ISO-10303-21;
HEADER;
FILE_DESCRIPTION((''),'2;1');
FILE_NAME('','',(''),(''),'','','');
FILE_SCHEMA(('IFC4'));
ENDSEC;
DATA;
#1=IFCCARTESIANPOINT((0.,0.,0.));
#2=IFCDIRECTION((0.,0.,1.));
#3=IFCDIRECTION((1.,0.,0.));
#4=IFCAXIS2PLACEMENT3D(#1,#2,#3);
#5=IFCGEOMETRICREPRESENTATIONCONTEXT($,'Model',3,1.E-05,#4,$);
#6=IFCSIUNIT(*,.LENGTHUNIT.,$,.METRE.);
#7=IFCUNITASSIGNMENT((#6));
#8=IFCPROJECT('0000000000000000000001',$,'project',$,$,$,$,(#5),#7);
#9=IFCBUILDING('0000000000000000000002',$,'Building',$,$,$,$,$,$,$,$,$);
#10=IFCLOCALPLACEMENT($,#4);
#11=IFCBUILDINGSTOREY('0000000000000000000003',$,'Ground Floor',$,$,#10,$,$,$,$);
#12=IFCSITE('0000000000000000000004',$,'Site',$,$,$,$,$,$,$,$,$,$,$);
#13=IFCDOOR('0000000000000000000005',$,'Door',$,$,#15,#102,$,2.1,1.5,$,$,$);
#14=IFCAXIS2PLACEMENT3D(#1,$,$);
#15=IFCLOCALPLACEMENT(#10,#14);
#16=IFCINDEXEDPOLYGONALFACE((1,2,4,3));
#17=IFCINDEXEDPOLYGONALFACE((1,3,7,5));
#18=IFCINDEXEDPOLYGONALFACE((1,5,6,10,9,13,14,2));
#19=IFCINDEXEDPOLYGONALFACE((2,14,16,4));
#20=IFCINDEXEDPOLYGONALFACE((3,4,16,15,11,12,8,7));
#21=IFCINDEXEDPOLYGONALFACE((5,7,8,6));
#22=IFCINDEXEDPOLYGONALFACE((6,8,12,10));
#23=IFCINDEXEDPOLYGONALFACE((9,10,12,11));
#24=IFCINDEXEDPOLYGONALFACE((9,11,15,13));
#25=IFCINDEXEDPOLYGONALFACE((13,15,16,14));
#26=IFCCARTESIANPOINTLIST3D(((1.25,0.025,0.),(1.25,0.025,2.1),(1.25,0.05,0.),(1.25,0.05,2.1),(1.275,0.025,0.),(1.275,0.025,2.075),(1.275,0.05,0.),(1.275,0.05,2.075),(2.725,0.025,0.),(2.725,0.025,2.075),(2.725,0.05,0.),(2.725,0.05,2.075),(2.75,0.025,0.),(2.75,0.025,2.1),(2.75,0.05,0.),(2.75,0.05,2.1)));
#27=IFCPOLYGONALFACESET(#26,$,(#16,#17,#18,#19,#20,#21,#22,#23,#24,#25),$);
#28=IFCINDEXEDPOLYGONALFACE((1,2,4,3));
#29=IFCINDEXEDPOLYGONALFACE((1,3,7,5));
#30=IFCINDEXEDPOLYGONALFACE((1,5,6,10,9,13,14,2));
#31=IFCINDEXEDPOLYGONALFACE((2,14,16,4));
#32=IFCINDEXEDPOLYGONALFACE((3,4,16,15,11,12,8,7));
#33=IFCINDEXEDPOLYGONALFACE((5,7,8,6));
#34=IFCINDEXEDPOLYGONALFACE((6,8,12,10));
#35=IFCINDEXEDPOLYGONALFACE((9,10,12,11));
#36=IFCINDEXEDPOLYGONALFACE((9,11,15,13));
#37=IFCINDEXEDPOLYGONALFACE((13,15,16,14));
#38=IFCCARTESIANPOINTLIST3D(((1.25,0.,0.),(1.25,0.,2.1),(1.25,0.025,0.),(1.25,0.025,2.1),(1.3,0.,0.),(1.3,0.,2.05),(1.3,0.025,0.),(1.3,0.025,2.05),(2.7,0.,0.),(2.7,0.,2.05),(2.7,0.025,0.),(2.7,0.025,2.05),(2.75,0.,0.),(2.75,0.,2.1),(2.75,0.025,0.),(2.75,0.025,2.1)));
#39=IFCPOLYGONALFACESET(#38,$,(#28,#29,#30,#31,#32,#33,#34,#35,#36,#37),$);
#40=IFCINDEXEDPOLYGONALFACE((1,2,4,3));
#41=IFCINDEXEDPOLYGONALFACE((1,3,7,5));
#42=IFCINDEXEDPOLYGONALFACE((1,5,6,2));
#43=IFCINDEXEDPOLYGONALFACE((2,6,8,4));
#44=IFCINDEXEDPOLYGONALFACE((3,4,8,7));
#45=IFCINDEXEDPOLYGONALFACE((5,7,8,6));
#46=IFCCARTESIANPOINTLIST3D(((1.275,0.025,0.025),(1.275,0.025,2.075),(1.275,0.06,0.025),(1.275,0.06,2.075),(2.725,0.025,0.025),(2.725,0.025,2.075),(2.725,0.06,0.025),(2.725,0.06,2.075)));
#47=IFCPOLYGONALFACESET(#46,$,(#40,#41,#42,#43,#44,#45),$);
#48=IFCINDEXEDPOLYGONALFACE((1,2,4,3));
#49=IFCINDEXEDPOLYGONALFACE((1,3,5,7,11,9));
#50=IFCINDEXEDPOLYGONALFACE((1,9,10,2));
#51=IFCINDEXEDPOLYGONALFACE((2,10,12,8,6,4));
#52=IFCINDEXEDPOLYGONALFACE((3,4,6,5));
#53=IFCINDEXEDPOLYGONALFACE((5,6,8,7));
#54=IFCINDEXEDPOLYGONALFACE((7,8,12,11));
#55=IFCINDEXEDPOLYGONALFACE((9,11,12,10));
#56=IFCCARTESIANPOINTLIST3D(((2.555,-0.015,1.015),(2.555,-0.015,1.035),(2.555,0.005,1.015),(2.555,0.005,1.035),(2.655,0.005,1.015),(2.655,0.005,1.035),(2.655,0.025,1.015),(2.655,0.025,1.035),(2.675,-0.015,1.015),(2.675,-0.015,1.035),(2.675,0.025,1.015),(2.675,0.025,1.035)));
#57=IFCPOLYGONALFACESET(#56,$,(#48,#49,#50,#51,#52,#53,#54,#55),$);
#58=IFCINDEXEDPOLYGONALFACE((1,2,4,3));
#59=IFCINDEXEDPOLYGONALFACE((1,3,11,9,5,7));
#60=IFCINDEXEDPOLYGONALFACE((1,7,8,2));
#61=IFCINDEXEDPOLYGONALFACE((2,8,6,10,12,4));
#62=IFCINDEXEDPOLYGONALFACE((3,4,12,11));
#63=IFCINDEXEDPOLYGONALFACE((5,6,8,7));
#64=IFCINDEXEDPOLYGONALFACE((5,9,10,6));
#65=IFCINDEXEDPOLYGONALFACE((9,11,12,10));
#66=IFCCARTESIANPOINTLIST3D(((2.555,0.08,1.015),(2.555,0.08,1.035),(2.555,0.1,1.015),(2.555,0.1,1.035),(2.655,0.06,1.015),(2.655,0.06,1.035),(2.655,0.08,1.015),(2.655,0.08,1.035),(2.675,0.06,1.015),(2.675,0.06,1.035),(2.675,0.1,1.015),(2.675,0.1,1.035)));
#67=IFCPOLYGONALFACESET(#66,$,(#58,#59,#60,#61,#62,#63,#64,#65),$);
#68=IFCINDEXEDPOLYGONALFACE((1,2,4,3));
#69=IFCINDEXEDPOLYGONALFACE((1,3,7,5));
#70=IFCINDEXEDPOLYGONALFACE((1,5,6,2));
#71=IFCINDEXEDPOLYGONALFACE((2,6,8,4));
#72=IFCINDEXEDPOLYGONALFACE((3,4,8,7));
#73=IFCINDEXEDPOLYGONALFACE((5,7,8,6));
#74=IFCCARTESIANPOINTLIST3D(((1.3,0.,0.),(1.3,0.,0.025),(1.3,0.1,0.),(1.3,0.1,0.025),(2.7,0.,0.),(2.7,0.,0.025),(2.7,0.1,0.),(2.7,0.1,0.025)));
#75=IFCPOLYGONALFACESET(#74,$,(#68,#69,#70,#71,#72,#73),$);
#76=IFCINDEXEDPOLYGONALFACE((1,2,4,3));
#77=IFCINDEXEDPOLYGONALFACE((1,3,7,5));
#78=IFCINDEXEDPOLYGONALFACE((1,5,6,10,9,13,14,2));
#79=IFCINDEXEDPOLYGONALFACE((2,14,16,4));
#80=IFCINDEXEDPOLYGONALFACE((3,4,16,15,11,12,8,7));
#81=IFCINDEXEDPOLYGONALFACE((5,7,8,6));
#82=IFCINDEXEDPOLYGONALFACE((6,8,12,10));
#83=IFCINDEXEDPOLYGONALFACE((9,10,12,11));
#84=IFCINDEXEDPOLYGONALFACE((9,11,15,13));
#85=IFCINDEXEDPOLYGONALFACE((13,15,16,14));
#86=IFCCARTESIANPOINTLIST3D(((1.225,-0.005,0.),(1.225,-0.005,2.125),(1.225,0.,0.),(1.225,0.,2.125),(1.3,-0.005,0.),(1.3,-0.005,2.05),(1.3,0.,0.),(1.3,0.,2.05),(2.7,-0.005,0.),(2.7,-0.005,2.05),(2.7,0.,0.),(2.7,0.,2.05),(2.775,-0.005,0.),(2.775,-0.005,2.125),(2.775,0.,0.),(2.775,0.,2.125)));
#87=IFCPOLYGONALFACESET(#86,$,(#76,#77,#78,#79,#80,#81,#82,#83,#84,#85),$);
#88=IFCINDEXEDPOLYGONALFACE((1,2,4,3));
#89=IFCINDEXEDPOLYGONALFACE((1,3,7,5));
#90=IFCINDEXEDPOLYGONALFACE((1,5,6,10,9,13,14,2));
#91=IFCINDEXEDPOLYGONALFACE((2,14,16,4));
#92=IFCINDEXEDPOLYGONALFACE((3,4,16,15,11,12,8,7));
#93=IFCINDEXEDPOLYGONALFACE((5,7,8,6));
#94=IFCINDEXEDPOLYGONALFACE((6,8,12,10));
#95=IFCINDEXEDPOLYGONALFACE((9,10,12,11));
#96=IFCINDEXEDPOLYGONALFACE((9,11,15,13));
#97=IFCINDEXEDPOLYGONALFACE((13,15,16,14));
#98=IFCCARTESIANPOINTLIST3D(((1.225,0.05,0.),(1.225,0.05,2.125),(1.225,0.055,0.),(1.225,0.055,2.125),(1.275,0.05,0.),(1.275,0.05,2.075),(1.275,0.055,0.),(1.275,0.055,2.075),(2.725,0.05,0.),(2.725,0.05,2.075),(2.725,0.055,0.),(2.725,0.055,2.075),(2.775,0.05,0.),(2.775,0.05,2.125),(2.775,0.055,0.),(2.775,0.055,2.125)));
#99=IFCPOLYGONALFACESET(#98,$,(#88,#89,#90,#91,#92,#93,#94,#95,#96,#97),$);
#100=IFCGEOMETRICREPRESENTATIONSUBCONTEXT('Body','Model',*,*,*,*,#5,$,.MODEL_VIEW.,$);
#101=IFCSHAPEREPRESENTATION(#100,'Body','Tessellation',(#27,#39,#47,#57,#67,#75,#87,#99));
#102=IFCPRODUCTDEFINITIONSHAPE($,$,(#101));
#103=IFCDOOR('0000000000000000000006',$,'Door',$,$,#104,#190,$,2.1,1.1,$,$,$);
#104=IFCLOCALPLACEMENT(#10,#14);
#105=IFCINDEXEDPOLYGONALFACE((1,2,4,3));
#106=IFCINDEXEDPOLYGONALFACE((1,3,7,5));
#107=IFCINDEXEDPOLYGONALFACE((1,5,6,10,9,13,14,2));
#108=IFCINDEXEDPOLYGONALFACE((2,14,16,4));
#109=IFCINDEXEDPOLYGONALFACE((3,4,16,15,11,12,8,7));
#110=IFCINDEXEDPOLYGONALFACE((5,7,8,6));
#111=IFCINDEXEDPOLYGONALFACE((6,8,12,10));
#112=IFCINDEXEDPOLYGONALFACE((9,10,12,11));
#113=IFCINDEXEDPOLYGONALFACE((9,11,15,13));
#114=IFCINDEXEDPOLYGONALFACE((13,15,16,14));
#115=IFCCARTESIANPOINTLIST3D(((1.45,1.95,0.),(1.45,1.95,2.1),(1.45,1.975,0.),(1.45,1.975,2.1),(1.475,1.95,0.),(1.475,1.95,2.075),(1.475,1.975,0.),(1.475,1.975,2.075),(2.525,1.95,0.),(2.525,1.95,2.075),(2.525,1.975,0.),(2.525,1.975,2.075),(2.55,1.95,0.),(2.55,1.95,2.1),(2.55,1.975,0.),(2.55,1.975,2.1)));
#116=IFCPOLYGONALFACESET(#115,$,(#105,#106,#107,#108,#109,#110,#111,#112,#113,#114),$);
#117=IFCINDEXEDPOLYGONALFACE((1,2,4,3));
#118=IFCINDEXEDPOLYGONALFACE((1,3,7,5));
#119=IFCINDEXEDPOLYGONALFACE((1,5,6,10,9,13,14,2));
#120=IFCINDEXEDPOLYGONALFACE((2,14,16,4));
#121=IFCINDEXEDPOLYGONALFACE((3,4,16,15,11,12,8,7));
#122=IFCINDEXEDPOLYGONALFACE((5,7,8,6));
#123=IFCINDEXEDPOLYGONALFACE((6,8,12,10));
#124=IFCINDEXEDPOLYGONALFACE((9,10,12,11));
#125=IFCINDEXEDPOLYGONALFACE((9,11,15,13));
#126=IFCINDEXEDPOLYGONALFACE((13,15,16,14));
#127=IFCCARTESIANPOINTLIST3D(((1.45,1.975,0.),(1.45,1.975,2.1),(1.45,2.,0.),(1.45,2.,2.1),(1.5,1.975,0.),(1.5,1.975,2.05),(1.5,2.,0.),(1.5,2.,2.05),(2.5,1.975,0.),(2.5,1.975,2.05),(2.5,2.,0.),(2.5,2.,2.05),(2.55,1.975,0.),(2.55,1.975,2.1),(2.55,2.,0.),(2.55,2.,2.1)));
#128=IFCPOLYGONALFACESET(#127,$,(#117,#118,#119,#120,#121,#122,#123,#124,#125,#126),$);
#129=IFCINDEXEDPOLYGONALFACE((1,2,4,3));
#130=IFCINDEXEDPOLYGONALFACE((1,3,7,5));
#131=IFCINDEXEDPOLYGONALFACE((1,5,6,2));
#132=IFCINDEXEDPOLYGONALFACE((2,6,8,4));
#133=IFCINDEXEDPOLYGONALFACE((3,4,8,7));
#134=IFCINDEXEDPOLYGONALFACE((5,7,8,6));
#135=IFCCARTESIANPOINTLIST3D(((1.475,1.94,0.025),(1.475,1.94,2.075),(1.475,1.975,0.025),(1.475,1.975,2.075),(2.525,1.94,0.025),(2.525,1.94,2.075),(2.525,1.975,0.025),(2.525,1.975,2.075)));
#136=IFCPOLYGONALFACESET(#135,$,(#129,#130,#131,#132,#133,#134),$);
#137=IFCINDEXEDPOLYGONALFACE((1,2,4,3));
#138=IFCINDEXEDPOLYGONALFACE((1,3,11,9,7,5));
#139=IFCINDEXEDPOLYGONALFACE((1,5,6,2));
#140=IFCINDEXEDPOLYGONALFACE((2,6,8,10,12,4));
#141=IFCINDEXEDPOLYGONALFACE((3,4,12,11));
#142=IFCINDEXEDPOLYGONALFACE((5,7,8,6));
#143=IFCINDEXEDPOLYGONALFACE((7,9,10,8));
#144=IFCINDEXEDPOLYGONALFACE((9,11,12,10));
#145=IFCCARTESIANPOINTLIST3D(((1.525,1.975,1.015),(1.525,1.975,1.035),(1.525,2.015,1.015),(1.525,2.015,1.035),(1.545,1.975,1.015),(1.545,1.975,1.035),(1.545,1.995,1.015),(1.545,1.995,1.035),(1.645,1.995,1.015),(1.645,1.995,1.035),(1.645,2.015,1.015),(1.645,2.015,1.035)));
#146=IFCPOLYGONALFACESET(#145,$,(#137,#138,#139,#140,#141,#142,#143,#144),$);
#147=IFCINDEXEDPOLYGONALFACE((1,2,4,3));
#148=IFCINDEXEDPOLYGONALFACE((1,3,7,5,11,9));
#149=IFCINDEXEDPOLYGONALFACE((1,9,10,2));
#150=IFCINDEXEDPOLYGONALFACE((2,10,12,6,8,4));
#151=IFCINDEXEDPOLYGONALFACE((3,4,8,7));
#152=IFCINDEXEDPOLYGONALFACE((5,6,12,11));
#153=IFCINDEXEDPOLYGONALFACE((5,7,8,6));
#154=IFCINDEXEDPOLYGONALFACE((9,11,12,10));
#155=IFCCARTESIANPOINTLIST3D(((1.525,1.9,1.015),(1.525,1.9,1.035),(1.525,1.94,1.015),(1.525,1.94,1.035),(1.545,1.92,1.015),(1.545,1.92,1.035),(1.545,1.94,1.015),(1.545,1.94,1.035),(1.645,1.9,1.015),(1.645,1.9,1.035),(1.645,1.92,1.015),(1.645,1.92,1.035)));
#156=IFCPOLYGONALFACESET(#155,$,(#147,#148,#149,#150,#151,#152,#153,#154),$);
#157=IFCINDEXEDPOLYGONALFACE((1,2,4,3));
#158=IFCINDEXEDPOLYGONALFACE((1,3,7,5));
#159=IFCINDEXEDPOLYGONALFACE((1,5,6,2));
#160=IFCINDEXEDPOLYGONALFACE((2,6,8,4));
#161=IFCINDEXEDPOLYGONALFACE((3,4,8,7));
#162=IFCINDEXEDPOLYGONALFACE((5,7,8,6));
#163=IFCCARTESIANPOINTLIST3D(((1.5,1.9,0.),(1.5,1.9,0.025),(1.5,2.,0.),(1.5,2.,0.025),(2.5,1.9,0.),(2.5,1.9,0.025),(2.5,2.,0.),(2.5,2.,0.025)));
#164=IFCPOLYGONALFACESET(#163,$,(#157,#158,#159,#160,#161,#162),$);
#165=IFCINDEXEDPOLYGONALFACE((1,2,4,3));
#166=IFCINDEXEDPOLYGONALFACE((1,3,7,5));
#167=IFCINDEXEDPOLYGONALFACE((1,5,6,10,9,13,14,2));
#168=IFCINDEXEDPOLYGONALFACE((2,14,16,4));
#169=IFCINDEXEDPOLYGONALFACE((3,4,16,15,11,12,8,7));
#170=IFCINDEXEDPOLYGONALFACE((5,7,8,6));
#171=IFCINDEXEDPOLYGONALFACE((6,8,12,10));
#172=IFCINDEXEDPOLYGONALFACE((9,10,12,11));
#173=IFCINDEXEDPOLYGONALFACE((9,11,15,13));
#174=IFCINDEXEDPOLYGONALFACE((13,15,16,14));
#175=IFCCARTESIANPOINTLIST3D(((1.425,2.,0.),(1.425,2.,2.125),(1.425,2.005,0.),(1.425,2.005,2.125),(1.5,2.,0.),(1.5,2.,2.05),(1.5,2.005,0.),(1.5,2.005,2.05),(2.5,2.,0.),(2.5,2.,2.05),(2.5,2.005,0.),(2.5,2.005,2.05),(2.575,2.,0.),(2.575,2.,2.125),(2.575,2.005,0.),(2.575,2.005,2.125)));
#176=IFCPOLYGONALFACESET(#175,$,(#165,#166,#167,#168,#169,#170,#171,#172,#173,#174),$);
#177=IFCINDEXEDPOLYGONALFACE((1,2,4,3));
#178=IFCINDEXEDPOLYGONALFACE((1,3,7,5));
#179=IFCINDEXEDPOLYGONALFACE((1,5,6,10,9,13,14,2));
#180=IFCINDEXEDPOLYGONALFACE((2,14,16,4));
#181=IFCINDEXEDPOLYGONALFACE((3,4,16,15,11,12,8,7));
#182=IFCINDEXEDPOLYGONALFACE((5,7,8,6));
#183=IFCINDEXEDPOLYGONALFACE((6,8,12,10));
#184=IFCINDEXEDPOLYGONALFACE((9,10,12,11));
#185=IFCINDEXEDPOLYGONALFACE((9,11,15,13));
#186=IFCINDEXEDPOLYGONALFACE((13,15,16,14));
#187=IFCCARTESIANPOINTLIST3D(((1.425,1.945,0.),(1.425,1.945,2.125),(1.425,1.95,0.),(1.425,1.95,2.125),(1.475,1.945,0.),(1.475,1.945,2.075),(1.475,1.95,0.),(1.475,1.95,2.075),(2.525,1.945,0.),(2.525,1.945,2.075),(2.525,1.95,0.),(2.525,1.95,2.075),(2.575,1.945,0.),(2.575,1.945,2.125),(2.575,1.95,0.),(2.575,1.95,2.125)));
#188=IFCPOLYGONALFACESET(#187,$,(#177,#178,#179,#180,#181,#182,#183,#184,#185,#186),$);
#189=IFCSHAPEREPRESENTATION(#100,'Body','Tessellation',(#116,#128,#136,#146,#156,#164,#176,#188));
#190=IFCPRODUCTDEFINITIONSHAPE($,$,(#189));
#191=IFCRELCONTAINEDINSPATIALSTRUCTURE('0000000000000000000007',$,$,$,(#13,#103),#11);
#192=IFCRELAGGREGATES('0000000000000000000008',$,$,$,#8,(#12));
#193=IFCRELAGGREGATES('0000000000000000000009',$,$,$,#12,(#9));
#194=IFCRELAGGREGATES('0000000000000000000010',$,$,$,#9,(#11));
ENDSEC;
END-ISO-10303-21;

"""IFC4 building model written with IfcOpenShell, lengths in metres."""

from ifc_helpers import new_model, si_unit, frame, origin_with_axes, place, context, subcontext, project, spatial, line, indexed_curve, outline, extrude, element, save


model = new_model("IFC4")

# Units and contexts
model_context = context("Model", 3, precision=1e-05, world=origin_with_axes())
body_context = subcontext(model_context, "Body", "Model", "MODEL_VIEW")
ifc_project = project(units=[si_unit("LENGTHUNIT", "METRE")], contexts=[model_context])

# Site, building, storey
site = spatial("IfcSite", under=ifc_project, Name="Site")
building = spatial("IfcBuilding", under=site, Name="Building")
storey_placement = place(None, origin_with_axes())
storey = spatial("IfcBuildingStorey", under=building, at=storey_placement, Name="Ground Floor")

# Doors
door_1_placement = place(storey_placement, frame((1.25, 0.0, 0.0), z_axis=(0.0, 0.0, 1.0), x_axis=(1.0, 0.0, 0.0)))
element("IfcDoor", 1, at=door_1_placement, inside=storey, Name="Door", OverallHeight=2.1, OverallWidth=1.5, context=body_context, shape_type="SweptSolid", body=[
    extrude(outline(indexed_curve([(0.0, 0.0), (0.0, 2.1), (1.5, 2.1), (1.5, 0.0), (1.475, 0.0), (1.475, 2.075), (0.025, 2.075), (0.025, 0.0)], segments=[line(1, 2, 3, 4, 5, 6, 7, 8, 1)])), frame((0.0, 0.025, 0.0), z_axis=(0.0, -1.0, 0.0), x_axis=(1.0, 0.0, 0.0)), (0.0, 0.0, -1.0), 0.025),
    extrude(outline(indexed_curve([(0.0, 0.0), (0.0, 2.1), (1.5, 2.1), (1.5, 0.0), (1.45, 0.0), (1.45, 2.05), (0.05, 2.05), (0.05, 0.0)], segments=[line(1, 2, 3, 4, 5, 6, 7, 8, 1)])), frame((0.0, 0.0, 0.0), z_axis=(0.0, -1.0, 0.0), x_axis=(1.0, 0.0, 0.0)), (0.0, 0.0, -1.0), 0.025),
    extrude(outline(indexed_curve([(0.0, 0.0), (1.45, 0.0), (1.45, 0.035), (0.0, 0.035)], segments=[line(1, 2, 3, 4, 1)])), frame((0.025, 0.025, 0.025), z_axis=(0.0, 0.0, 1.0), x_axis=(1.0, 0.0, 0.0)), (0.0, 0.0, 1.0), 2.05),
    extrude(outline(indexed_curve([(0.0, 0.0), (0.0, -0.04), (-0.12, -0.04), (-0.12, -0.02), (-0.02, -0.02), (-0.02, 0.0)], segments=[line(1, 2, 3, 4, 5, 6, 1)])), frame((1.425, 0.025, 1.015), z_axis=(0.0, 0.0, 1.0), x_axis=(1.0, 0.0, 0.0)), (0.0, 0.0, 1.0), 0.02),
    extrude(outline(indexed_curve([(0.0, 0.0), (0.0, 0.04), (-0.12, 0.04), (-0.12, 0.02), (-0.02, 0.02), (-0.02, 0.0)], segments=[line(1, 2, 3, 4, 5, 6, 1)])), frame((1.425, 0.06, 1.015), z_axis=(0.0, 0.0, 1.0), x_axis=(1.0, 0.0, 0.0)), (0.0, 0.0, 1.0), 0.02),
    extrude(outline(indexed_curve([(0.0, 0.0), (1.4, 0.0), (1.4, 0.1), (0.0, 0.1)], segments=[line(1, 2, 3, 4, 1)])), frame((0.05, 0.0, 0.0), z_axis=(0.0, 0.0, 1.0), x_axis=(1.0, 0.0, 0.0)), (0.0, 0.0, 1.0), 0.025),
    extrude(outline(indexed_curve([(0.0, 0.0), (0.0, 2.125), (1.55, 2.125), (1.55, 0.0), (1.475, 0.0), (1.475, 2.05), (0.075, 2.05), (0.075, 0.0)], segments=[line(1, 2, 3, 4, 5, 6, 7, 8, 1)])), frame((-0.025, -0.005, 0.0), z_axis=(0.0, -1.0, 0.0), x_axis=(1.0, 0.0, 0.0)), (0.0, 0.0, -1.0), 0.005),
    extrude(outline(indexed_curve([(0.0, 0.0), (0.0, 2.125), (1.55, 2.125), (1.55, 0.0), (1.5, 0.0), (1.5, 2.075), (0.05, 2.075), (0.05, 0.0)], segments=[line(1, 2, 3, 4, 5, 6, 7, 8, 1)])), frame((-0.025, 0.05, 0.0), z_axis=(0.0, -1.0, 0.0), x_axis=(1.0, 0.0, 0.0)), (0.0, 0.0, -1.0), 0.005),
])
door_2_placement = place(storey_placement, frame((2.55, 2.0, 0.0), z_axis=(0.0, 0.0, 1.0), x_axis=(-1.0, 0.0, 0.0)))
element("IfcDoor", 2, at=door_2_placement, inside=storey, Name="Door", OverallHeight=2.1, OverallWidth=1.1, context=body_context, shape_type="SweptSolid", body=[
    extrude(outline(indexed_curve([(0.0, 0.0), (0.0, 2.1), (1.1, 2.1), (1.1, 0.0), (1.075, 0.0), (1.075, 2.075), (0.025, 2.075), (0.025, 0.0)], segments=[line(1, 2, 3, 4, 5, 6, 7, 8, 1)])), frame((0.0, 0.025, 0.0), z_axis=(0.0, -1.0, 0.0), x_axis=(1.0, 0.0, 0.0)), (0.0, 0.0, -1.0), 0.025),
    extrude(outline(indexed_curve([(0.0, 0.0), (0.0, 2.1), (1.1, 2.1), (1.1, 0.0), (1.05, 0.0), (1.05, 2.05), (0.05, 2.05), (0.05, 0.0)], segments=[line(1, 2, 3, 4, 5, 6, 7, 8, 1)])), frame((0.0, 0.0, 0.0), z_axis=(0.0, -1.0, 0.0), x_axis=(1.0, 0.0, 0.0)), (0.0, 0.0, -1.0), 0.025),
    extrude(outline(indexed_curve([(0.0, 0.0), (1.05, 0.0), (1.05, 0.035), (0.0, 0.035)], segments=[line(1, 2, 3, 4, 1)])), frame((0.025, 0.025, 0.025), z_axis=(0.0, 0.0, 1.0), x_axis=(1.0, 0.0, 0.0)), (0.0, 0.0, 1.0), 2.05),
    extrude(outline(indexed_curve([(0.0, 0.0), (0.0, -0.04), (-0.12, -0.04), (-0.12, -0.02), (-0.02, -0.02), (-0.02, 0.0)], segments=[line(1, 2, 3, 4, 5, 6, 1)])), frame((1.025, 0.025, 1.015), z_axis=(0.0, 0.0, 1.0), x_axis=(1.0, 0.0, 0.0)), (0.0, 0.0, 1.0), 0.02),
    extrude(outline(indexed_curve([(0.0, 0.0), (0.0, 0.04), (-0.12, 0.04), (-0.12, 0.02), (-0.02, 0.02), (-0.02, 0.0)], segments=[line(1, 2, 3, 4, 5, 6, 1)])), frame((1.025, 0.06, 1.015), z_axis=(0.0, 0.0, 1.0), x_axis=(1.0, 0.0, 0.0)), (0.0, 0.0, 1.0), 0.02),
    extrude(outline(indexed_curve([(0.0, 0.0), (1.0, 0.0), (1.0, 0.1), (0.0, 0.1)], segments=[line(1, 2, 3, 4, 1)])), frame((0.05, 0.0, 0.0), z_axis=(0.0, 0.0, 1.0), x_axis=(1.0, 0.0, 0.0)), (0.0, 0.0, 1.0), 0.025),
    extrude(outline(indexed_curve([(0.0, 0.0), (0.0, 2.125), (1.15, 2.125), (1.15, 0.0), (1.075, 0.0), (1.075, 2.05), (0.075, 2.05), (0.075, 0.0)], segments=[line(1, 2, 3, 4, 5, 6, 7, 8, 1)])), frame((-0.025, -0.005, 0.0), z_axis=(0.0, -1.0, 0.0), x_axis=(1.0, 0.0, 0.0)), (0.0, 0.0, -1.0), 0.005),
    extrude(outline(indexed_curve([(0.0, 0.0), (0.0, 2.125), (1.15, 2.125), (1.15, 0.0), (1.1, 0.0), (1.1, 2.075), (0.05, 2.075), (0.05, 0.0)], segments=[line(1, 2, 3, 4, 5, 6, 7, 8, 1)])), frame((-0.025, 0.05, 0.0), z_axis=(0.0, -1.0, 0.0), x_axis=(1.0, 0.0, 0.0)), (0.0, 0.0, -1.0), 0.005),
])

save(model, "model.ifc")
